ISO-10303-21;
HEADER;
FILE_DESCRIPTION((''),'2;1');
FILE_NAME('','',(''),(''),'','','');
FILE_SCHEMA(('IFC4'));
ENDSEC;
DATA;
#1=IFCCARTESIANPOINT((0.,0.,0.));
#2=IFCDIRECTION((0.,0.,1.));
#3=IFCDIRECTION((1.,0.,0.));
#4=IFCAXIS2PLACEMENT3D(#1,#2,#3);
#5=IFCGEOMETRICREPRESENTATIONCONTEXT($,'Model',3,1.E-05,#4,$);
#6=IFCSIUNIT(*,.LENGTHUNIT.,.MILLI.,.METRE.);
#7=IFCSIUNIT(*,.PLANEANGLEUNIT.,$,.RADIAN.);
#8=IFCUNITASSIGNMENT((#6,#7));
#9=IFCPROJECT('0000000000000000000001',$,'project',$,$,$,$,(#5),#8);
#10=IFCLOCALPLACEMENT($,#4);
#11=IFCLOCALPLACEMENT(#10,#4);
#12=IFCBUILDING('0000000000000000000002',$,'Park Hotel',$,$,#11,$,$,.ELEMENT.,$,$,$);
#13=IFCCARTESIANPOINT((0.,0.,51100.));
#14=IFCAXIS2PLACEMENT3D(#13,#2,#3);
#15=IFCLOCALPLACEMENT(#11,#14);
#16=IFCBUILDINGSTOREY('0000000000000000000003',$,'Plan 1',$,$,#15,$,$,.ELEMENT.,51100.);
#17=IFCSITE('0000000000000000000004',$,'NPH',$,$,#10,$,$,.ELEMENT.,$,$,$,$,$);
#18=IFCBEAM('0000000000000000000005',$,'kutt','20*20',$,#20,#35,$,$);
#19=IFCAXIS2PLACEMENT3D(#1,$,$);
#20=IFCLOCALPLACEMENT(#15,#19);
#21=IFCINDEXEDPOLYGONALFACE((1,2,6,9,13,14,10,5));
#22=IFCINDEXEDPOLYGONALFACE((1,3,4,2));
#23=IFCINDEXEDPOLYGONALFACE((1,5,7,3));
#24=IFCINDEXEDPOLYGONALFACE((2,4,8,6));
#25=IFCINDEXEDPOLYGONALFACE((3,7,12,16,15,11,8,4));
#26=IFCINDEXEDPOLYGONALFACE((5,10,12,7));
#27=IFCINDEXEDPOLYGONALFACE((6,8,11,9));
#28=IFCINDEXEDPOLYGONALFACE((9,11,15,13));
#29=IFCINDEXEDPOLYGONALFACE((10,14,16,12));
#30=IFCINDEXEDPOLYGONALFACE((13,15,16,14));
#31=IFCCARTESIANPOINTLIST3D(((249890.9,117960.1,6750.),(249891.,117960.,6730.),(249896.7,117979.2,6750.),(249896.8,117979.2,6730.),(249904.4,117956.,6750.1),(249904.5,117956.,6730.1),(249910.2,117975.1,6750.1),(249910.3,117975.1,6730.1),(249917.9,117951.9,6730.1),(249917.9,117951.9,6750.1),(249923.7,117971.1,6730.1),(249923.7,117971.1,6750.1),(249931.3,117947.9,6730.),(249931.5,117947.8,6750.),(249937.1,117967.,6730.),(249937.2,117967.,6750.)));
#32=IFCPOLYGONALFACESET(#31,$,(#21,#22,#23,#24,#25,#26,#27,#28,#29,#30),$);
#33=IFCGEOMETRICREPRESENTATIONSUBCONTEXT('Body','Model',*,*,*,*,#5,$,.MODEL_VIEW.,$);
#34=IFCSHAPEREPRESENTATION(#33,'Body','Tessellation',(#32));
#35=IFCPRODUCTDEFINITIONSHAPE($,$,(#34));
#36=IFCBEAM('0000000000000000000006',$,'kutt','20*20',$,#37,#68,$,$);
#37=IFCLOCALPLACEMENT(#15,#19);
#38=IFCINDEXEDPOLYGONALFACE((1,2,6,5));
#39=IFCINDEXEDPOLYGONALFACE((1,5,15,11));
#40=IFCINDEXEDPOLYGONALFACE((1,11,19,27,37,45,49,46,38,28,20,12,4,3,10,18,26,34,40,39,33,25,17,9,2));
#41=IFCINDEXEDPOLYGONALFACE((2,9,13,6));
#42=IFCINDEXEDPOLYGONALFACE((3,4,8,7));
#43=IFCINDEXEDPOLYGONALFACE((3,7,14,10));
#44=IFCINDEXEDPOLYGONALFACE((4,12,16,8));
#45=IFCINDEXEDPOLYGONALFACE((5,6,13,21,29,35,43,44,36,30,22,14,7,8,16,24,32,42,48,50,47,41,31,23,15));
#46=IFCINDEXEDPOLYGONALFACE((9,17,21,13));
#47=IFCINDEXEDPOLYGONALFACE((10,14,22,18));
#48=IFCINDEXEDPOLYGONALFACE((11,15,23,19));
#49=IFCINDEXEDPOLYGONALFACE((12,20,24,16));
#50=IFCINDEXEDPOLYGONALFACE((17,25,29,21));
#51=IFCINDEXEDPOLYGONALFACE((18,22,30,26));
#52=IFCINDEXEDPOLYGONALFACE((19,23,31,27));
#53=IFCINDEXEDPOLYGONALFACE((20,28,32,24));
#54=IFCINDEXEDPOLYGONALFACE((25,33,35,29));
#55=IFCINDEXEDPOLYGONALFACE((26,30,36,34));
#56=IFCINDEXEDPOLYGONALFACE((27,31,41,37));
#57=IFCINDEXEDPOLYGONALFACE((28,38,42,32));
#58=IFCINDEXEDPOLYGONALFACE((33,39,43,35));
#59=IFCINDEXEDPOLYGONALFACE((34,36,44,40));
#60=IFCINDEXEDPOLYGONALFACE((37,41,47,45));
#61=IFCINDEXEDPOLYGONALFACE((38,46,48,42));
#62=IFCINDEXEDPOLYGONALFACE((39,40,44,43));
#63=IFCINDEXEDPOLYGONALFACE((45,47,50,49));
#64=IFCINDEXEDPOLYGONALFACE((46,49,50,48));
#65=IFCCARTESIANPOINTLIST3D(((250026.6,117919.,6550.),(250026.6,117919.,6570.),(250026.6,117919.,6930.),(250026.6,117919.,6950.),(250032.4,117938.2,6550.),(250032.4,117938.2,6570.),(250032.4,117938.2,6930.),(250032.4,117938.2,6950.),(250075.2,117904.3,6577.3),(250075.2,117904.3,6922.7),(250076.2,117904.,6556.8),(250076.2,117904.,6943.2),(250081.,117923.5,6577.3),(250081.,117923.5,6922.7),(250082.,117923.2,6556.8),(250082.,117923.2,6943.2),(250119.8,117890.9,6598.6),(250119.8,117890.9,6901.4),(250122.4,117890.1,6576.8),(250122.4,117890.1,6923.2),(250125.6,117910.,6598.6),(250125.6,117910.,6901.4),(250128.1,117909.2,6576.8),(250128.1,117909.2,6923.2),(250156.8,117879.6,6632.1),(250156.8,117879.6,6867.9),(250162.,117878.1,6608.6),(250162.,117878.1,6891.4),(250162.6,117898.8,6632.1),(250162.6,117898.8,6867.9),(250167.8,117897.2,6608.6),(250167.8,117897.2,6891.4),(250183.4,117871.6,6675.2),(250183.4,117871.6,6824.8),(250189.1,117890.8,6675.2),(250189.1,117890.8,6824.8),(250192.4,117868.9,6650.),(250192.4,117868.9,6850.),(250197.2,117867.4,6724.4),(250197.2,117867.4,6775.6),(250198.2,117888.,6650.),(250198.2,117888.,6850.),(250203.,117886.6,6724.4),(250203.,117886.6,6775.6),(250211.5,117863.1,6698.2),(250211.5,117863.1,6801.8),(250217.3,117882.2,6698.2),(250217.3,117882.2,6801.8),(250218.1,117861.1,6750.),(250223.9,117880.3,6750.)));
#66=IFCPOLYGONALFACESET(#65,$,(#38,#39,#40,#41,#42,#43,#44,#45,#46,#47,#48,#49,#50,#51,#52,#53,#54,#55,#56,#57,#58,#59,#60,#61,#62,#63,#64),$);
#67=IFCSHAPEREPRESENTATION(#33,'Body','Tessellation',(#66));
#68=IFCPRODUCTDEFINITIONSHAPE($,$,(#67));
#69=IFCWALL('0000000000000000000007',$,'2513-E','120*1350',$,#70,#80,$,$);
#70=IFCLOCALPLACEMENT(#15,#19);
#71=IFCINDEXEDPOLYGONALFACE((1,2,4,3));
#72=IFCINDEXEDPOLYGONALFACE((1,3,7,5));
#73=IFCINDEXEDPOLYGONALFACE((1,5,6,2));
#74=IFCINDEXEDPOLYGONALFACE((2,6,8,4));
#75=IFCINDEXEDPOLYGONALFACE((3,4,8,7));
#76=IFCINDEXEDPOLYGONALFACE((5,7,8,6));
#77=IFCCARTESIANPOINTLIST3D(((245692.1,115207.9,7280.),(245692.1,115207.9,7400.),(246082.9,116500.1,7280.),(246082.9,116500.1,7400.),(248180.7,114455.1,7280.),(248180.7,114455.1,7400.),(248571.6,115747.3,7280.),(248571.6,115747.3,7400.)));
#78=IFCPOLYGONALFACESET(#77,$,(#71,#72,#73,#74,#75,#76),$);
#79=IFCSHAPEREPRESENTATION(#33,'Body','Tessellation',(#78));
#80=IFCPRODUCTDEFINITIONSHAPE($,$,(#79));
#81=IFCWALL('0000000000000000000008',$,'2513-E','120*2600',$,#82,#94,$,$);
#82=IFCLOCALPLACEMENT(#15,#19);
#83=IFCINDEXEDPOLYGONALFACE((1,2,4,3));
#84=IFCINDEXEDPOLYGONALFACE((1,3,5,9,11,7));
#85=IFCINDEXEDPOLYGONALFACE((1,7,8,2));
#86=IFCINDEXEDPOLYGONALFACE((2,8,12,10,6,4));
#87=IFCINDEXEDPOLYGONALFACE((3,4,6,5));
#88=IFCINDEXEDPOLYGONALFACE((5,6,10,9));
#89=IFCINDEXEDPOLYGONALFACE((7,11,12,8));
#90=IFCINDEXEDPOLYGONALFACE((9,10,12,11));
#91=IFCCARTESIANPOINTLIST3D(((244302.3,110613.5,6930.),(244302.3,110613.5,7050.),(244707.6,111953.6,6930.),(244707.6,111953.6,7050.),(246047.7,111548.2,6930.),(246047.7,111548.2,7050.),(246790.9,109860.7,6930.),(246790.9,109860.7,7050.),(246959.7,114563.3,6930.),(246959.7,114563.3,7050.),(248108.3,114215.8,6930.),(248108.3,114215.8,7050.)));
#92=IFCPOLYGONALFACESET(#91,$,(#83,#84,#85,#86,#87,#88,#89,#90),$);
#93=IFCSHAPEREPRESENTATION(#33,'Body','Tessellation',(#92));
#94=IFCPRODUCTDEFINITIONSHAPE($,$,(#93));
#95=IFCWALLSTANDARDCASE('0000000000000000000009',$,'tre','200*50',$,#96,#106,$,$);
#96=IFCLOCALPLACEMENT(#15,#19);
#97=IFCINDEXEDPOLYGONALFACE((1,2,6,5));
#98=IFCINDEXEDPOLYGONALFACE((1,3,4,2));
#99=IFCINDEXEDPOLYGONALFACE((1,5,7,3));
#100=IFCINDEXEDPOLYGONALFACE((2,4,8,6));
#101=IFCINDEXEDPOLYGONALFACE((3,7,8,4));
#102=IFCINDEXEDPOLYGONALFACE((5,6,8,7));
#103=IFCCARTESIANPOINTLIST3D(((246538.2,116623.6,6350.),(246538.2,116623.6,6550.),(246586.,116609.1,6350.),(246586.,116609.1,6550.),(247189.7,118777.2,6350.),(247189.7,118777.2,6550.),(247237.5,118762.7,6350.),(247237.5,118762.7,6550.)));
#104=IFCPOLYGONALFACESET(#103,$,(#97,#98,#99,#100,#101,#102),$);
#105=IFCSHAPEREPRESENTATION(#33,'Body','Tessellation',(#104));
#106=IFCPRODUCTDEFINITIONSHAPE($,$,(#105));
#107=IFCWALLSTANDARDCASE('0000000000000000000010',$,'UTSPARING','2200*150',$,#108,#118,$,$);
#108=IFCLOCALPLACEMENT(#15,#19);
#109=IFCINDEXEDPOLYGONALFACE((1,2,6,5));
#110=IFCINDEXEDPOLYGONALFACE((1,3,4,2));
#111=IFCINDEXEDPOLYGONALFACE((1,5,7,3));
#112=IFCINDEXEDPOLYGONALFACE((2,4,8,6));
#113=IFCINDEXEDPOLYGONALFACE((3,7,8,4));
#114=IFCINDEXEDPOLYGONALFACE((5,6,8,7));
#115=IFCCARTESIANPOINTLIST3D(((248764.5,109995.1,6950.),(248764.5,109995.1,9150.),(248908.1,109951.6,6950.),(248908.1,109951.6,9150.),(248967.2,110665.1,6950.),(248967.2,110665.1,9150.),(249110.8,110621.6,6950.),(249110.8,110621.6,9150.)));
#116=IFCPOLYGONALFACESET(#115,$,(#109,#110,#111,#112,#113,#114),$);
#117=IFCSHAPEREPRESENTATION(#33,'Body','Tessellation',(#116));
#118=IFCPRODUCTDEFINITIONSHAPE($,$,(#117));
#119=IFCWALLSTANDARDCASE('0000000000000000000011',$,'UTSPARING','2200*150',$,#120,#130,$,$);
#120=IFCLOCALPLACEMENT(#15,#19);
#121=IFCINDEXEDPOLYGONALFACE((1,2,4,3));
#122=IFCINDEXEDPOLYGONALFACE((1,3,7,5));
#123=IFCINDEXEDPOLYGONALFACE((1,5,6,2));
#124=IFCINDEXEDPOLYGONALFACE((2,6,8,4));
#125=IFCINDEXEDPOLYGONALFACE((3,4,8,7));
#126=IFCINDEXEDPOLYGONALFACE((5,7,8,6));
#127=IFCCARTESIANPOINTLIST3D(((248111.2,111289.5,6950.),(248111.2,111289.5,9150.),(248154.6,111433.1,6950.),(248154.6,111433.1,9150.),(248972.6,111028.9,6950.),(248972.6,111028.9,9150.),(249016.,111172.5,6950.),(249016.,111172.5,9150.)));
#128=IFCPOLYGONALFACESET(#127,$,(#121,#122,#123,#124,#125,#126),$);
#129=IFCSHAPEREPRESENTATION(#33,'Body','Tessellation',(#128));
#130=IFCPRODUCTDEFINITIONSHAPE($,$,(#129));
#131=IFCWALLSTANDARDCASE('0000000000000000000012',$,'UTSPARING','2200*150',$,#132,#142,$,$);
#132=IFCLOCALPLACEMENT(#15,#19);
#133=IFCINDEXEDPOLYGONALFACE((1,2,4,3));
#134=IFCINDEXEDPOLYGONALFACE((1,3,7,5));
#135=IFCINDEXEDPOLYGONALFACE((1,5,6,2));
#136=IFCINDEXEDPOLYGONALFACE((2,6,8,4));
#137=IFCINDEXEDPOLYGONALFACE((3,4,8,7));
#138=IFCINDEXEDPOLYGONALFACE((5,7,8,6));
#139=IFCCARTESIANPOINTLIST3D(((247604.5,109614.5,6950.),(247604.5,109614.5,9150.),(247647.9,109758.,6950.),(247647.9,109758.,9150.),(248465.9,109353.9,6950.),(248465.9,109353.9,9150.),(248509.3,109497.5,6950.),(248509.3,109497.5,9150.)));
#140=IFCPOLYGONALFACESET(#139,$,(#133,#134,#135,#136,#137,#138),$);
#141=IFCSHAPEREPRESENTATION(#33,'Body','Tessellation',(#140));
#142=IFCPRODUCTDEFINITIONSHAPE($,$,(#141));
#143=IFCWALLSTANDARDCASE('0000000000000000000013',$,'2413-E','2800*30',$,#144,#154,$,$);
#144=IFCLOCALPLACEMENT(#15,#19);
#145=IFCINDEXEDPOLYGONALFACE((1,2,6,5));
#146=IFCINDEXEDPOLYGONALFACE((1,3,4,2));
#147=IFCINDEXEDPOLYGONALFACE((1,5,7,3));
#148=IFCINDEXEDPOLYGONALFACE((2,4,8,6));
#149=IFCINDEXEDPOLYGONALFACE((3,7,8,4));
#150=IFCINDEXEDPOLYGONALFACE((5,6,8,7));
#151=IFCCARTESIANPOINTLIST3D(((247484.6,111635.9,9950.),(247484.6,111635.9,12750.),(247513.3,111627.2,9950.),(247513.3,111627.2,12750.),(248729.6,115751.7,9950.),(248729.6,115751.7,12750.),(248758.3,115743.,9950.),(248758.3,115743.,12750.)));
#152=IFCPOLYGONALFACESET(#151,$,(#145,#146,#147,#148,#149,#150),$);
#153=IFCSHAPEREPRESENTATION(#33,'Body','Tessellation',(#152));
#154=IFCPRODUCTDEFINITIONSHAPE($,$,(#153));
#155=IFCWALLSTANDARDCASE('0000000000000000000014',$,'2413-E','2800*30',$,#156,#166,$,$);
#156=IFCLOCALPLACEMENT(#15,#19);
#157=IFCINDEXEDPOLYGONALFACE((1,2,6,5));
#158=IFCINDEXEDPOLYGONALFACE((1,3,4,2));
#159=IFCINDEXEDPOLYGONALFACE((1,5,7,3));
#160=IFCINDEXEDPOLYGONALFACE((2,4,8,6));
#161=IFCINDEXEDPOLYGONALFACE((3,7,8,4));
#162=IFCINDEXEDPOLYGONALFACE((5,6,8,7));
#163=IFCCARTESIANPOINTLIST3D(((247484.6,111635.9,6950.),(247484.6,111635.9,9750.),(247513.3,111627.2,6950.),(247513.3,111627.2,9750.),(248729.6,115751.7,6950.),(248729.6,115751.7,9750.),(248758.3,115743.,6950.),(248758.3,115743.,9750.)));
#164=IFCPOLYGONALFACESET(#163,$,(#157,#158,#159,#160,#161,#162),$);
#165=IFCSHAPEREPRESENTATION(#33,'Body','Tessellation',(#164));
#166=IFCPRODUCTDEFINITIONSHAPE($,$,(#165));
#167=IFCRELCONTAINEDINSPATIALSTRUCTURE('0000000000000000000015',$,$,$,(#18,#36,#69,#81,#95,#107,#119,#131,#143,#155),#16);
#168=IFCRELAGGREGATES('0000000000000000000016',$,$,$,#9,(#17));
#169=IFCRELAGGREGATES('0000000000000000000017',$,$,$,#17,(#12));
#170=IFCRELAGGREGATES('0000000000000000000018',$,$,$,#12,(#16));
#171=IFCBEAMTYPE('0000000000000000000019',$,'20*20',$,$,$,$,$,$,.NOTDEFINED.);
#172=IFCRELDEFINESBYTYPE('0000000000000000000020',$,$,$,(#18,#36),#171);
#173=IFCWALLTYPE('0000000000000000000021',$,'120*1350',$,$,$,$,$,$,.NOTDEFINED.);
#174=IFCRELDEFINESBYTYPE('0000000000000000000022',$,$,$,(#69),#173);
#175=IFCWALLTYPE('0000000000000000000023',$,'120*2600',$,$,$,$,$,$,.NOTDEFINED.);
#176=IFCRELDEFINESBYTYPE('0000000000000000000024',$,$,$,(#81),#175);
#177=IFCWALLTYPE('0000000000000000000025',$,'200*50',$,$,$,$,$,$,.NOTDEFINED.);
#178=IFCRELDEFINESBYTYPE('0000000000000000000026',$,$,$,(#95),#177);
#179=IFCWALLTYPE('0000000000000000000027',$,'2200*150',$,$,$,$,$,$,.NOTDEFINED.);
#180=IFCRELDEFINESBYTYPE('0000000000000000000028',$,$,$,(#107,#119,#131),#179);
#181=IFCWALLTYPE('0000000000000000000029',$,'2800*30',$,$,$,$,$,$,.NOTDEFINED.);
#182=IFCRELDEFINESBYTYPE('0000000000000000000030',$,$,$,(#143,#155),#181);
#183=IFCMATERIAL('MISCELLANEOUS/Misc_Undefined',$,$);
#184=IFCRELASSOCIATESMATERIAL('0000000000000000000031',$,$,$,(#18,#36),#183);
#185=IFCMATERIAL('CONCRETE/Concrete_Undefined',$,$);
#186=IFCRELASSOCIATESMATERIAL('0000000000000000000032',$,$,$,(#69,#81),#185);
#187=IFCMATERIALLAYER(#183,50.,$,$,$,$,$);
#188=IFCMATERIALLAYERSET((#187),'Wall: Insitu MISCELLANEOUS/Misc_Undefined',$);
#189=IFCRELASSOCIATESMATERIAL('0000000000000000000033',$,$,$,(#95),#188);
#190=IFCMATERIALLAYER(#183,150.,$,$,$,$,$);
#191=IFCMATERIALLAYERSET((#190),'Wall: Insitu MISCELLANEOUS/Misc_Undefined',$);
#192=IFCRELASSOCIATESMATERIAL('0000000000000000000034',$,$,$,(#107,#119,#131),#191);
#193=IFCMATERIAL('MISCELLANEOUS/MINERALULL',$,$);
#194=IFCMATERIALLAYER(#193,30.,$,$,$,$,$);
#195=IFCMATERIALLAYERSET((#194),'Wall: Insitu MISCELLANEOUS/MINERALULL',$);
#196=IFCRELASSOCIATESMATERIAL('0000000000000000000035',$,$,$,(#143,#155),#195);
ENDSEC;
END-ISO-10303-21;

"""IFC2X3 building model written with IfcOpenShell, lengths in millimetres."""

from ifc_helpers import new_model, entity, si_unit, frame, frame_2d, origin_with_axes, place, context, subcontext, project, spatial, polyline, rectangle, outline, extrude, material, layer, layer_set, layer_usage, type_object, element, save


model = new_model("IFC2X3")

# Units and contexts
model_context = context("Model", 3, precision=1e-05, world=origin_with_axes())
body_context = subcontext(model_context, "Body", "Model", "MODEL_VIEW")
ifc_project = project(units=[si_unit("LENGTHUNIT", "METRE", prefix="MILLI"), si_unit("PLANEANGLEUNIT", "RADIAN")], contexts=[model_context])

# Site, building, storey
site_placement = place(None, origin_with_axes())
site = spatial("IfcSite", under=ifc_project, at=site_placement, Name="NPH", CompositionType="ELEMENT")
building_placement = place(site_placement, origin_with_axes())
building = spatial("IfcBuilding", under=site, at=building_placement, Name="Park Hotel", CompositionType="ELEMENT")
storey_placement = place(building_placement, frame((0.0, 0.0, 51100.0), z_axis=(0.0, 0.0, 1.0), x_axis=(1.0, 0.0, 0.0)))
storey = spatial("IfcBuildingStorey", under=building, at=storey_placement, Name="Plan 1", CompositionType="ELEMENT", Elevation=51100.0)

# Beams
ifc_material_1 = material(Name="MISCELLANEOUS/Misc_Undefined")
beam_type_1 = type_object("IfcBeamType", Name="20*20", PredefinedType="NOTDEFINED")
beam_1_placement = place(storey_placement, frame((249934.3, 117957.4, 6740.0), z_axis=(-0.28954, -0.957166, 0.0), x_axis=(-0.957166, 0.289539, 0.0)))
element("IfcBeam", 1, at=beam_1_placement, inside=storey, type_object=beam_type_1, material=ifc_material_1, Name="kutt", Description="20*20", context=body_context, shape_type="SweptSolid", body=[
    entity("IfcRevolvedAreaSolid", entity("IfcRectangleProfileDef", "AREA", None, entity("IfcAxis2Placement2D", entity("IfcCartesianPoint", [0.0, 0.0]), entity("IfcDirection", [1.0, 0.0])), 20.0, 20.0), entity("IfcAxis2Placement3D", entity("IfcCartesianPoint", [42.2, 0.0, 0.0]), entity("IfcDirection", [-0.999975, -0.00706, 0.0]), entity("IfcDirection", [0.00706, -0.999975, 0.0])), entity("IfcAxis1Placement", entity("IfcCartesianPoint", [-2990.0, 0.0, 0.0]), entity("IfcDirection", [0.0, -1.0, 0.0])), 0.01412),
])
beam_2_placement = place(storey_placement, frame((250029.5, 117928.6, 6940.0), z_axis=(0.289538, 0.957167, -0.000001), x_axis=(0.0, -0.000001, -1.0)))
ifc_direction_1 = entity("IfcDirection", [0.0, -1.0, 0.0])
element("IfcBeam", 2, at=beam_2_placement, inside=storey, type_object=beam_type_1, material=ifc_material_1, Name="kutt", Description="20*20", context=body_context, shape_type="SweptSolid", body=[
    entity("IfcRevolvedAreaSolid", entity("IfcRectangleProfileDef", "AREA", None, entity("IfcAxis2Placement2D", entity("IfcCartesianPoint", [0.0, 0.0]), entity("IfcDirection", [1.0, 0.0])), 20.0, 20.0), entity("IfcAxis2Placement3D", entity("IfcCartesianPoint", [380.0, 0.0, 0.0]), ifc_direction_1, entity("IfcDirection", [1.0, 0.0, 0.0])), entity("IfcAxis1Placement", entity("IfcCartesianPoint", [-190.0, 0.0, 0.0]), ifc_direction_1), 3.141593),
])

# Walls
ifc_material_2 = material(Name="CONCRETE/Concrete_Undefined")
wall_type_1 = type_object("IfcWallType", Name="120*1350", PredefinedType="NOTDEFINED")
wall_1_placement = place(storey_placement, frame((248180.7, 114455.1, 7340.0), z_axis=(0.0, 0.0, 1.0), x_axis=(0.289538, 0.957167, 0.0)))
element("IfcWall", 3, at=wall_1_placement, inside=storey, type_object=wall_type_1, material=ifc_material_2, Name="2513-E", Description="120*1350", context=body_context, shape_type="SweptSolid", body=[
    extrude(outline(polyline([(0.0, 0.0), (1350.0, 0.0), (1350.0, 2600.0), (0.0, 2600.0), (0.0, 0.0)])), frame((0.0, 0.0, -60.0), z_axis=(0.0, 0.0, 1.0), x_axis=(1.0, 0.0, 0.0)), (0.0, 0.0, 1.0), 120.0),
])
wall_type_2 = type_object("IfcWallType", Name="120*2600", PredefinedType="NOTDEFINED")
wall_2_placement = place(storey_placement, frame((246790.9, 109860.7, 6990.0), z_axis=(0.0, 0.0, 1.0), x_axis=(0.289538, 0.957167, 0.0)))
element("IfcWall", 4, at=wall_2_placement, inside=storey, type_object=wall_type_2, material=ifc_material_2, Name="2513-E", Description="120*2600", context=body_context, shape_type="SweptSolid", body=[
    extrude(outline(polyline([(0.0, 0.0), (4550.0, 0.0), (4550.0, 1200.0), (1400.0, 1200.0), (1400.0, 2600.0), (0.0, 2600.0), (0.0, 0.0)])), frame((0.0, 0.0, -60.0), z_axis=(0.0, 0.0, 1.0), x_axis=(1.0, 0.0, 0.0)), (0.0, 0.0, 1.0), 120.0),
])
ifc_layer_1 = layer(ifc_material_1, 50.0)
ifc_layer_set_1 = layer_set([ifc_layer_1], Name="Wall: Insitu MISCELLANEOUS/Misc_Undefined")
ifc_layer_usage_1 = layer_usage(ifc_layer_set_1, "AXIS2", "POSITIVE", -25.0)
wall_type_3 = type_object("IfcWallType", Name="200*50", PredefinedType="NOTDEFINED")
wall_3_placement = place(storey_placement, frame((247213.6, 118770.0, 6350.0), z_axis=(0.0, 0.0, 1.0), x_axis=(-0.289538, -0.957167, 0.0)))
element("IfcWallStandardCase", 5, at=wall_3_placement, inside=storey, type_object=wall_type_3, material=ifc_layer_usage_1, Name="tre", Description="200*50", context=body_context, shape_type="SweptSolid", body=[
    extrude(rectangle(XDim=2250.0, YDim=50.0, at=frame_2d((0.0, 1125.0), x_axis=(0.0, -1.0))), frame((0.0, 0.0, 0.0), z_axis=(0.0, 0.0, 1.0), x_axis=(0.0, -1.0, 0.0)), (0.0, 0.0, 1.0), 200.0),
])
ifc_layer_2 = layer(ifc_material_1, 150.0)
ifc_layer_set_2 = layer_set([ifc_layer_2], Name="Wall: Insitu MISCELLANEOUS/Misc_Undefined")
ifc_layer_usage_2 = layer_usage(ifc_layer_set_2, "AXIS2", "POSITIVE", -75.0)
wall_type_4 = type_object("IfcWallType", Name="2200*150", PredefinedType="NOTDEFINED")
wall_4_placement = place(storey_placement, frame((249039.0, 110643.4, 6950.0), z_axis=(0.0, 0.0, 1.0), x_axis=(-0.289534, -0.957168, 0.0)))
element("IfcWallStandardCase", 6, at=wall_4_placement, inside=storey, type_object=wall_type_4, material=ifc_layer_usage_2, Name="UTSPARING", Description="2200*150", context=body_context, shape_type="SweptSolid", body=[
    extrude(rectangle(XDim=700.0, YDim=150.0, at=frame_2d((0.0, 350.0), x_axis=(0.0, -1.0))), frame((0.0, 0.0, 0.0), z_axis=(0.0, 0.0, 1.0), x_axis=(0.0, -1.0, 0.0)), (0.0, 0.0, 1.0), 2200.0),
])
ifc_layer_usage_3 = layer_usage(ifc_layer_set_2, "AXIS2", "POSITIVE", -75.0)
wall_5_placement = place(storey_placement, frame((248132.9, 111361.3, 6950.0), z_axis=(0.0, 0.0, 1.0), x_axis=(0.957166, -0.289541, 0.0)))
element("IfcWallStandardCase", 7, at=wall_5_placement, inside=storey, type_object=wall_type_4, material=ifc_layer_usage_3, Name="UTSPARING", Description="2200*150", context=body_context, shape_type="SweptSolid", body=[
    extrude(rectangle(XDim=900.0, YDim=150.0, at=frame_2d((0.0, 450.0), x_axis=(0.0, -1.0))), frame((0.0, 0.0, 0.0), z_axis=(0.0, 0.0, 1.0), x_axis=(0.0, -1.0, 0.0)), (0.0, 0.0, 1.0), 2200.0),
])
ifc_layer_usage_4 = layer_usage(ifc_layer_set_2, "AXIS2", "POSITIVE", -75.0)
wall_6_placement = place(storey_placement, frame((247626.2, 109686.3, 6950.0), z_axis=(0.0, 0.0, 1.0), x_axis=(0.957166, -0.289541, 0.0)))
element("IfcWallStandardCase", 8, at=wall_6_placement, inside=storey, type_object=wall_type_4, material=ifc_layer_usage_4, Name="UTSPARING", Description="2200*150", context=body_context, shape_type="SweptSolid", body=[
    extrude(rectangle(XDim=900.0, YDim=150.0, at=frame_2d((0.0, 450.0), x_axis=(0.0, -1.0))), frame((0.0, 0.0, 0.0), z_axis=(0.0, 0.0, 1.0), x_axis=(0.0, -1.0, 0.0)), (0.0, 0.0, 1.0), 2200.0),
])
ifc_material_3 = material(Name="MISCELLANEOUS/MINERALULL")
ifc_layer_3 = layer(ifc_material_3, 30.0)
ifc_layer_set_3 = layer_set([ifc_layer_3], Name="Wall: Insitu MISCELLANEOUS/MINERALULL")
ifc_layer_usage_5 = layer_usage(ifc_layer_set_3, "AXIS2", "POSITIVE", -15.0)
wall_type_5 = type_object("IfcWallType", Name="2800*30", PredefinedType="NOTDEFINED")
wall_7_placement = place(storey_placement, frame((247499.0, 111631.6, 9950.0), z_axis=(0.0, 0.0, 1.0), x_axis=(0.289537, 0.957167, 0.0)))
element("IfcWallStandardCase", 9, at=wall_7_placement, inside=storey, type_object=wall_type_5, material=ifc_layer_usage_5, Name="2413-E", Description="2800*30", context=body_context, shape_type="SweptSolid", body=[
    extrude(rectangle(XDim=4300.0, YDim=30.0, at=frame_2d((0.0, 2150.0), x_axis=(0.0, -1.0))), frame((0.0, 0.0, 0.0), z_axis=(0.0, 0.0, 1.0), x_axis=(0.0, -1.0, 0.0)), (0.0, 0.0, 1.0), 2800.0),
])
ifc_layer_usage_6 = layer_usage(ifc_layer_set_3, "AXIS2", "POSITIVE", -15.0)
wall_8_placement = place(storey_placement, frame((247499.0, 111631.6, 6950.0), z_axis=(0.0, 0.0, 1.0), x_axis=(0.289537, 0.957167, 0.0)))
element("IfcWallStandardCase", 10, at=wall_8_placement, inside=storey, type_object=wall_type_5, material=ifc_layer_usage_6, Name="2413-E", Description="2800*30", context=body_context, shape_type="SweptSolid", body=[
    extrude(rectangle(XDim=4300.0, YDim=30.0, at=frame_2d((0.0, 2150.0), x_axis=(0.0, -1.0))), frame((0.0, 0.0, 0.0), z_axis=(0.0, 0.0, 1.0), x_axis=(0.0, -1.0, 0.0)), (0.0, 0.0, 1.0), 2800.0),
])

save(model, "model.ifc")
